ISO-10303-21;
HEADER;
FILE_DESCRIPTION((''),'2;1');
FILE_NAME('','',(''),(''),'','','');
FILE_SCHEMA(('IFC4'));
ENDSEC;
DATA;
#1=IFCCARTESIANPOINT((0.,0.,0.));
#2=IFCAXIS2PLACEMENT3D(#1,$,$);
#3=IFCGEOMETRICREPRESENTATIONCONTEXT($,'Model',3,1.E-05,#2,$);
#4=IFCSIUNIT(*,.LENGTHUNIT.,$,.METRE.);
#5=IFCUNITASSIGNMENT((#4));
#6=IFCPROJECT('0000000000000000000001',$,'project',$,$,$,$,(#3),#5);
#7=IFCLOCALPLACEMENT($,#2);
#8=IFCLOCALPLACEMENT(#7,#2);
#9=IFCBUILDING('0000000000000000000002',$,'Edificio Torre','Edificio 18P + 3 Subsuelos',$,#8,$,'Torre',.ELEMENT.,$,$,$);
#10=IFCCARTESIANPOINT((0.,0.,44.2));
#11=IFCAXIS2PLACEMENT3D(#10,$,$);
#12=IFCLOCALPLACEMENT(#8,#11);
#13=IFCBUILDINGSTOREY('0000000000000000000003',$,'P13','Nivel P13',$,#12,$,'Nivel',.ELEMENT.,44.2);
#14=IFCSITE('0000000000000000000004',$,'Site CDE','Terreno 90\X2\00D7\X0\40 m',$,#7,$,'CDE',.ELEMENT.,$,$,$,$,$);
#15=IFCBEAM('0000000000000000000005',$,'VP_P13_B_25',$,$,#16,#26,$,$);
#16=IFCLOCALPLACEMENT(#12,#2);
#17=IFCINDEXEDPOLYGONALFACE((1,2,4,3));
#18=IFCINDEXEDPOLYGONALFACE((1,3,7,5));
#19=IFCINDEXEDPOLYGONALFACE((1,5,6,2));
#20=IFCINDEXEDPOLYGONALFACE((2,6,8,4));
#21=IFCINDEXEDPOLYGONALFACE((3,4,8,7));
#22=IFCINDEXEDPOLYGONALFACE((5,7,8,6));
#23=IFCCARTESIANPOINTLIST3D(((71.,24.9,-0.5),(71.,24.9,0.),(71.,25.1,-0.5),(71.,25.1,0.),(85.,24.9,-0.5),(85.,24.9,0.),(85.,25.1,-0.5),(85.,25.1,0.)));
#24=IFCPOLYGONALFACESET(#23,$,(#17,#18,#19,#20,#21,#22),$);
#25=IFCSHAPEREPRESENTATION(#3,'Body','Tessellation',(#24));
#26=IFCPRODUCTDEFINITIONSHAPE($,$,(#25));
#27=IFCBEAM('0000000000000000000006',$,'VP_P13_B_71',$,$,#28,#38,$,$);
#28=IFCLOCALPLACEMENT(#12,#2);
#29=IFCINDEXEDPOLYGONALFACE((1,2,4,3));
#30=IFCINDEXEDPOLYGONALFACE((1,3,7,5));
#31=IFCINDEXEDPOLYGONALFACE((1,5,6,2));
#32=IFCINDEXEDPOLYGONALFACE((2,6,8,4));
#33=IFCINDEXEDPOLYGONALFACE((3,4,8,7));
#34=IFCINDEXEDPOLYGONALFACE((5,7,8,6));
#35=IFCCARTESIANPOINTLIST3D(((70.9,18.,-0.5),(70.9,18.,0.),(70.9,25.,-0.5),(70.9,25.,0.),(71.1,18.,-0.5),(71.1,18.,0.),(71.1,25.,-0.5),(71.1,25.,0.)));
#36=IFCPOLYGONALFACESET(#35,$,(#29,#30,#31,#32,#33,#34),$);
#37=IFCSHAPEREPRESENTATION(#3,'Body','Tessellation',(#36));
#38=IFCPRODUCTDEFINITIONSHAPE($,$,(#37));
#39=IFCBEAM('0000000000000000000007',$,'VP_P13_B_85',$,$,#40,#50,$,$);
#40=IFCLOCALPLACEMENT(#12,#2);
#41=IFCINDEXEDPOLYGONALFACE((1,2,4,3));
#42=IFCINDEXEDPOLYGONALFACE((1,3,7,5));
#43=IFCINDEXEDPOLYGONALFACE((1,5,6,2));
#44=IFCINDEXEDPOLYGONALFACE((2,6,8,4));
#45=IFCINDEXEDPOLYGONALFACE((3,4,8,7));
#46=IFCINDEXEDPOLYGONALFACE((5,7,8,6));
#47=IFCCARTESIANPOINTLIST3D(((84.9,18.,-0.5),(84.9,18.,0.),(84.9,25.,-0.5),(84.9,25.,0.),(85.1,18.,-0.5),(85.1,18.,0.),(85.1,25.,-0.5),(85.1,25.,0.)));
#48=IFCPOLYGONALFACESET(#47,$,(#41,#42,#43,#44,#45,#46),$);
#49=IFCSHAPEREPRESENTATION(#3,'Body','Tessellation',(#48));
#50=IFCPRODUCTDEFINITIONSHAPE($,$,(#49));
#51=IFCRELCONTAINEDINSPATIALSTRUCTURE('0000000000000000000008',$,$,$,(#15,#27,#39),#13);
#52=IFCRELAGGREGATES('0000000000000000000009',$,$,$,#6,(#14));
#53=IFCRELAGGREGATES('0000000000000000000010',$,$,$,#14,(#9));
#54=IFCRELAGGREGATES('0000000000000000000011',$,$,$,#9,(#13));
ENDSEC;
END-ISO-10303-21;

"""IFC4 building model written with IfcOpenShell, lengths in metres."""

from ifc_helpers import new_model, si_unit, frame, origin, origin_2d, place, context, project, spatial, rectangle, extrude, element, save


model = new_model("IFC4")

# Units and contexts
model_context = context("Model", 3, precision=1e-05, world=origin())
ifc_project = project(units=[si_unit("LENGTHUNIT", "METRE")], contexts=[model_context])

# Site, building, storey
site_placement = place(None, origin())
site = spatial("IfcSite", under=ifc_project, at=site_placement, Name="Site CDE", Description="Terreno 90×40 m", LongName="CDE", CompositionType="ELEMENT")
building_placement = place(site_placement, origin())
building = spatial("IfcBuilding", under=site, at=building_placement, Name="Edificio Torre", Description="Edificio 18P + 3 Subsuelos", LongName="Torre", CompositionType="ELEMENT")
storey_placement = place(building_placement, frame((0.0, 0.0, 44.2)))
storey = spatial("IfcBuildingStorey", under=building, at=storey_placement, Name="P13", Description="Nivel P13", LongName="Nivel", CompositionType="ELEMENT", Elevation=44.2)

# Beams
for number, where, name in (
    (1, (78.0, 25.0, -0.5), "VP_P13_B_25"),
):
    element("IfcBeam", number, at=place(storey_placement, frame(where)), inside=storey, Name=name, context=model_context, shape_type="SweptSolid", body=[
        extrude(rectangle(XDim=14.0, YDim=0.2, at=origin_2d()), origin(), (0.0, 0.0, 1.0), 0.5),
    ])
for number, where, name in (
    (2, (71.0, 21.5, -0.5), "VP_P13_B_71"),
    (3, (85.0, 21.5, -0.5), "VP_P13_B_85"),
):
    element("IfcBeam", number, at=place(storey_placement, frame(where)), inside=storey, Name=name, context=model_context, shape_type="SweptSolid", body=[
        extrude(rectangle(XDim=0.2, YDim=7.0, at=origin_2d()), origin(), (0.0, 0.0, 1.0), 0.5),
    ])

save(model, "model.ifc")
